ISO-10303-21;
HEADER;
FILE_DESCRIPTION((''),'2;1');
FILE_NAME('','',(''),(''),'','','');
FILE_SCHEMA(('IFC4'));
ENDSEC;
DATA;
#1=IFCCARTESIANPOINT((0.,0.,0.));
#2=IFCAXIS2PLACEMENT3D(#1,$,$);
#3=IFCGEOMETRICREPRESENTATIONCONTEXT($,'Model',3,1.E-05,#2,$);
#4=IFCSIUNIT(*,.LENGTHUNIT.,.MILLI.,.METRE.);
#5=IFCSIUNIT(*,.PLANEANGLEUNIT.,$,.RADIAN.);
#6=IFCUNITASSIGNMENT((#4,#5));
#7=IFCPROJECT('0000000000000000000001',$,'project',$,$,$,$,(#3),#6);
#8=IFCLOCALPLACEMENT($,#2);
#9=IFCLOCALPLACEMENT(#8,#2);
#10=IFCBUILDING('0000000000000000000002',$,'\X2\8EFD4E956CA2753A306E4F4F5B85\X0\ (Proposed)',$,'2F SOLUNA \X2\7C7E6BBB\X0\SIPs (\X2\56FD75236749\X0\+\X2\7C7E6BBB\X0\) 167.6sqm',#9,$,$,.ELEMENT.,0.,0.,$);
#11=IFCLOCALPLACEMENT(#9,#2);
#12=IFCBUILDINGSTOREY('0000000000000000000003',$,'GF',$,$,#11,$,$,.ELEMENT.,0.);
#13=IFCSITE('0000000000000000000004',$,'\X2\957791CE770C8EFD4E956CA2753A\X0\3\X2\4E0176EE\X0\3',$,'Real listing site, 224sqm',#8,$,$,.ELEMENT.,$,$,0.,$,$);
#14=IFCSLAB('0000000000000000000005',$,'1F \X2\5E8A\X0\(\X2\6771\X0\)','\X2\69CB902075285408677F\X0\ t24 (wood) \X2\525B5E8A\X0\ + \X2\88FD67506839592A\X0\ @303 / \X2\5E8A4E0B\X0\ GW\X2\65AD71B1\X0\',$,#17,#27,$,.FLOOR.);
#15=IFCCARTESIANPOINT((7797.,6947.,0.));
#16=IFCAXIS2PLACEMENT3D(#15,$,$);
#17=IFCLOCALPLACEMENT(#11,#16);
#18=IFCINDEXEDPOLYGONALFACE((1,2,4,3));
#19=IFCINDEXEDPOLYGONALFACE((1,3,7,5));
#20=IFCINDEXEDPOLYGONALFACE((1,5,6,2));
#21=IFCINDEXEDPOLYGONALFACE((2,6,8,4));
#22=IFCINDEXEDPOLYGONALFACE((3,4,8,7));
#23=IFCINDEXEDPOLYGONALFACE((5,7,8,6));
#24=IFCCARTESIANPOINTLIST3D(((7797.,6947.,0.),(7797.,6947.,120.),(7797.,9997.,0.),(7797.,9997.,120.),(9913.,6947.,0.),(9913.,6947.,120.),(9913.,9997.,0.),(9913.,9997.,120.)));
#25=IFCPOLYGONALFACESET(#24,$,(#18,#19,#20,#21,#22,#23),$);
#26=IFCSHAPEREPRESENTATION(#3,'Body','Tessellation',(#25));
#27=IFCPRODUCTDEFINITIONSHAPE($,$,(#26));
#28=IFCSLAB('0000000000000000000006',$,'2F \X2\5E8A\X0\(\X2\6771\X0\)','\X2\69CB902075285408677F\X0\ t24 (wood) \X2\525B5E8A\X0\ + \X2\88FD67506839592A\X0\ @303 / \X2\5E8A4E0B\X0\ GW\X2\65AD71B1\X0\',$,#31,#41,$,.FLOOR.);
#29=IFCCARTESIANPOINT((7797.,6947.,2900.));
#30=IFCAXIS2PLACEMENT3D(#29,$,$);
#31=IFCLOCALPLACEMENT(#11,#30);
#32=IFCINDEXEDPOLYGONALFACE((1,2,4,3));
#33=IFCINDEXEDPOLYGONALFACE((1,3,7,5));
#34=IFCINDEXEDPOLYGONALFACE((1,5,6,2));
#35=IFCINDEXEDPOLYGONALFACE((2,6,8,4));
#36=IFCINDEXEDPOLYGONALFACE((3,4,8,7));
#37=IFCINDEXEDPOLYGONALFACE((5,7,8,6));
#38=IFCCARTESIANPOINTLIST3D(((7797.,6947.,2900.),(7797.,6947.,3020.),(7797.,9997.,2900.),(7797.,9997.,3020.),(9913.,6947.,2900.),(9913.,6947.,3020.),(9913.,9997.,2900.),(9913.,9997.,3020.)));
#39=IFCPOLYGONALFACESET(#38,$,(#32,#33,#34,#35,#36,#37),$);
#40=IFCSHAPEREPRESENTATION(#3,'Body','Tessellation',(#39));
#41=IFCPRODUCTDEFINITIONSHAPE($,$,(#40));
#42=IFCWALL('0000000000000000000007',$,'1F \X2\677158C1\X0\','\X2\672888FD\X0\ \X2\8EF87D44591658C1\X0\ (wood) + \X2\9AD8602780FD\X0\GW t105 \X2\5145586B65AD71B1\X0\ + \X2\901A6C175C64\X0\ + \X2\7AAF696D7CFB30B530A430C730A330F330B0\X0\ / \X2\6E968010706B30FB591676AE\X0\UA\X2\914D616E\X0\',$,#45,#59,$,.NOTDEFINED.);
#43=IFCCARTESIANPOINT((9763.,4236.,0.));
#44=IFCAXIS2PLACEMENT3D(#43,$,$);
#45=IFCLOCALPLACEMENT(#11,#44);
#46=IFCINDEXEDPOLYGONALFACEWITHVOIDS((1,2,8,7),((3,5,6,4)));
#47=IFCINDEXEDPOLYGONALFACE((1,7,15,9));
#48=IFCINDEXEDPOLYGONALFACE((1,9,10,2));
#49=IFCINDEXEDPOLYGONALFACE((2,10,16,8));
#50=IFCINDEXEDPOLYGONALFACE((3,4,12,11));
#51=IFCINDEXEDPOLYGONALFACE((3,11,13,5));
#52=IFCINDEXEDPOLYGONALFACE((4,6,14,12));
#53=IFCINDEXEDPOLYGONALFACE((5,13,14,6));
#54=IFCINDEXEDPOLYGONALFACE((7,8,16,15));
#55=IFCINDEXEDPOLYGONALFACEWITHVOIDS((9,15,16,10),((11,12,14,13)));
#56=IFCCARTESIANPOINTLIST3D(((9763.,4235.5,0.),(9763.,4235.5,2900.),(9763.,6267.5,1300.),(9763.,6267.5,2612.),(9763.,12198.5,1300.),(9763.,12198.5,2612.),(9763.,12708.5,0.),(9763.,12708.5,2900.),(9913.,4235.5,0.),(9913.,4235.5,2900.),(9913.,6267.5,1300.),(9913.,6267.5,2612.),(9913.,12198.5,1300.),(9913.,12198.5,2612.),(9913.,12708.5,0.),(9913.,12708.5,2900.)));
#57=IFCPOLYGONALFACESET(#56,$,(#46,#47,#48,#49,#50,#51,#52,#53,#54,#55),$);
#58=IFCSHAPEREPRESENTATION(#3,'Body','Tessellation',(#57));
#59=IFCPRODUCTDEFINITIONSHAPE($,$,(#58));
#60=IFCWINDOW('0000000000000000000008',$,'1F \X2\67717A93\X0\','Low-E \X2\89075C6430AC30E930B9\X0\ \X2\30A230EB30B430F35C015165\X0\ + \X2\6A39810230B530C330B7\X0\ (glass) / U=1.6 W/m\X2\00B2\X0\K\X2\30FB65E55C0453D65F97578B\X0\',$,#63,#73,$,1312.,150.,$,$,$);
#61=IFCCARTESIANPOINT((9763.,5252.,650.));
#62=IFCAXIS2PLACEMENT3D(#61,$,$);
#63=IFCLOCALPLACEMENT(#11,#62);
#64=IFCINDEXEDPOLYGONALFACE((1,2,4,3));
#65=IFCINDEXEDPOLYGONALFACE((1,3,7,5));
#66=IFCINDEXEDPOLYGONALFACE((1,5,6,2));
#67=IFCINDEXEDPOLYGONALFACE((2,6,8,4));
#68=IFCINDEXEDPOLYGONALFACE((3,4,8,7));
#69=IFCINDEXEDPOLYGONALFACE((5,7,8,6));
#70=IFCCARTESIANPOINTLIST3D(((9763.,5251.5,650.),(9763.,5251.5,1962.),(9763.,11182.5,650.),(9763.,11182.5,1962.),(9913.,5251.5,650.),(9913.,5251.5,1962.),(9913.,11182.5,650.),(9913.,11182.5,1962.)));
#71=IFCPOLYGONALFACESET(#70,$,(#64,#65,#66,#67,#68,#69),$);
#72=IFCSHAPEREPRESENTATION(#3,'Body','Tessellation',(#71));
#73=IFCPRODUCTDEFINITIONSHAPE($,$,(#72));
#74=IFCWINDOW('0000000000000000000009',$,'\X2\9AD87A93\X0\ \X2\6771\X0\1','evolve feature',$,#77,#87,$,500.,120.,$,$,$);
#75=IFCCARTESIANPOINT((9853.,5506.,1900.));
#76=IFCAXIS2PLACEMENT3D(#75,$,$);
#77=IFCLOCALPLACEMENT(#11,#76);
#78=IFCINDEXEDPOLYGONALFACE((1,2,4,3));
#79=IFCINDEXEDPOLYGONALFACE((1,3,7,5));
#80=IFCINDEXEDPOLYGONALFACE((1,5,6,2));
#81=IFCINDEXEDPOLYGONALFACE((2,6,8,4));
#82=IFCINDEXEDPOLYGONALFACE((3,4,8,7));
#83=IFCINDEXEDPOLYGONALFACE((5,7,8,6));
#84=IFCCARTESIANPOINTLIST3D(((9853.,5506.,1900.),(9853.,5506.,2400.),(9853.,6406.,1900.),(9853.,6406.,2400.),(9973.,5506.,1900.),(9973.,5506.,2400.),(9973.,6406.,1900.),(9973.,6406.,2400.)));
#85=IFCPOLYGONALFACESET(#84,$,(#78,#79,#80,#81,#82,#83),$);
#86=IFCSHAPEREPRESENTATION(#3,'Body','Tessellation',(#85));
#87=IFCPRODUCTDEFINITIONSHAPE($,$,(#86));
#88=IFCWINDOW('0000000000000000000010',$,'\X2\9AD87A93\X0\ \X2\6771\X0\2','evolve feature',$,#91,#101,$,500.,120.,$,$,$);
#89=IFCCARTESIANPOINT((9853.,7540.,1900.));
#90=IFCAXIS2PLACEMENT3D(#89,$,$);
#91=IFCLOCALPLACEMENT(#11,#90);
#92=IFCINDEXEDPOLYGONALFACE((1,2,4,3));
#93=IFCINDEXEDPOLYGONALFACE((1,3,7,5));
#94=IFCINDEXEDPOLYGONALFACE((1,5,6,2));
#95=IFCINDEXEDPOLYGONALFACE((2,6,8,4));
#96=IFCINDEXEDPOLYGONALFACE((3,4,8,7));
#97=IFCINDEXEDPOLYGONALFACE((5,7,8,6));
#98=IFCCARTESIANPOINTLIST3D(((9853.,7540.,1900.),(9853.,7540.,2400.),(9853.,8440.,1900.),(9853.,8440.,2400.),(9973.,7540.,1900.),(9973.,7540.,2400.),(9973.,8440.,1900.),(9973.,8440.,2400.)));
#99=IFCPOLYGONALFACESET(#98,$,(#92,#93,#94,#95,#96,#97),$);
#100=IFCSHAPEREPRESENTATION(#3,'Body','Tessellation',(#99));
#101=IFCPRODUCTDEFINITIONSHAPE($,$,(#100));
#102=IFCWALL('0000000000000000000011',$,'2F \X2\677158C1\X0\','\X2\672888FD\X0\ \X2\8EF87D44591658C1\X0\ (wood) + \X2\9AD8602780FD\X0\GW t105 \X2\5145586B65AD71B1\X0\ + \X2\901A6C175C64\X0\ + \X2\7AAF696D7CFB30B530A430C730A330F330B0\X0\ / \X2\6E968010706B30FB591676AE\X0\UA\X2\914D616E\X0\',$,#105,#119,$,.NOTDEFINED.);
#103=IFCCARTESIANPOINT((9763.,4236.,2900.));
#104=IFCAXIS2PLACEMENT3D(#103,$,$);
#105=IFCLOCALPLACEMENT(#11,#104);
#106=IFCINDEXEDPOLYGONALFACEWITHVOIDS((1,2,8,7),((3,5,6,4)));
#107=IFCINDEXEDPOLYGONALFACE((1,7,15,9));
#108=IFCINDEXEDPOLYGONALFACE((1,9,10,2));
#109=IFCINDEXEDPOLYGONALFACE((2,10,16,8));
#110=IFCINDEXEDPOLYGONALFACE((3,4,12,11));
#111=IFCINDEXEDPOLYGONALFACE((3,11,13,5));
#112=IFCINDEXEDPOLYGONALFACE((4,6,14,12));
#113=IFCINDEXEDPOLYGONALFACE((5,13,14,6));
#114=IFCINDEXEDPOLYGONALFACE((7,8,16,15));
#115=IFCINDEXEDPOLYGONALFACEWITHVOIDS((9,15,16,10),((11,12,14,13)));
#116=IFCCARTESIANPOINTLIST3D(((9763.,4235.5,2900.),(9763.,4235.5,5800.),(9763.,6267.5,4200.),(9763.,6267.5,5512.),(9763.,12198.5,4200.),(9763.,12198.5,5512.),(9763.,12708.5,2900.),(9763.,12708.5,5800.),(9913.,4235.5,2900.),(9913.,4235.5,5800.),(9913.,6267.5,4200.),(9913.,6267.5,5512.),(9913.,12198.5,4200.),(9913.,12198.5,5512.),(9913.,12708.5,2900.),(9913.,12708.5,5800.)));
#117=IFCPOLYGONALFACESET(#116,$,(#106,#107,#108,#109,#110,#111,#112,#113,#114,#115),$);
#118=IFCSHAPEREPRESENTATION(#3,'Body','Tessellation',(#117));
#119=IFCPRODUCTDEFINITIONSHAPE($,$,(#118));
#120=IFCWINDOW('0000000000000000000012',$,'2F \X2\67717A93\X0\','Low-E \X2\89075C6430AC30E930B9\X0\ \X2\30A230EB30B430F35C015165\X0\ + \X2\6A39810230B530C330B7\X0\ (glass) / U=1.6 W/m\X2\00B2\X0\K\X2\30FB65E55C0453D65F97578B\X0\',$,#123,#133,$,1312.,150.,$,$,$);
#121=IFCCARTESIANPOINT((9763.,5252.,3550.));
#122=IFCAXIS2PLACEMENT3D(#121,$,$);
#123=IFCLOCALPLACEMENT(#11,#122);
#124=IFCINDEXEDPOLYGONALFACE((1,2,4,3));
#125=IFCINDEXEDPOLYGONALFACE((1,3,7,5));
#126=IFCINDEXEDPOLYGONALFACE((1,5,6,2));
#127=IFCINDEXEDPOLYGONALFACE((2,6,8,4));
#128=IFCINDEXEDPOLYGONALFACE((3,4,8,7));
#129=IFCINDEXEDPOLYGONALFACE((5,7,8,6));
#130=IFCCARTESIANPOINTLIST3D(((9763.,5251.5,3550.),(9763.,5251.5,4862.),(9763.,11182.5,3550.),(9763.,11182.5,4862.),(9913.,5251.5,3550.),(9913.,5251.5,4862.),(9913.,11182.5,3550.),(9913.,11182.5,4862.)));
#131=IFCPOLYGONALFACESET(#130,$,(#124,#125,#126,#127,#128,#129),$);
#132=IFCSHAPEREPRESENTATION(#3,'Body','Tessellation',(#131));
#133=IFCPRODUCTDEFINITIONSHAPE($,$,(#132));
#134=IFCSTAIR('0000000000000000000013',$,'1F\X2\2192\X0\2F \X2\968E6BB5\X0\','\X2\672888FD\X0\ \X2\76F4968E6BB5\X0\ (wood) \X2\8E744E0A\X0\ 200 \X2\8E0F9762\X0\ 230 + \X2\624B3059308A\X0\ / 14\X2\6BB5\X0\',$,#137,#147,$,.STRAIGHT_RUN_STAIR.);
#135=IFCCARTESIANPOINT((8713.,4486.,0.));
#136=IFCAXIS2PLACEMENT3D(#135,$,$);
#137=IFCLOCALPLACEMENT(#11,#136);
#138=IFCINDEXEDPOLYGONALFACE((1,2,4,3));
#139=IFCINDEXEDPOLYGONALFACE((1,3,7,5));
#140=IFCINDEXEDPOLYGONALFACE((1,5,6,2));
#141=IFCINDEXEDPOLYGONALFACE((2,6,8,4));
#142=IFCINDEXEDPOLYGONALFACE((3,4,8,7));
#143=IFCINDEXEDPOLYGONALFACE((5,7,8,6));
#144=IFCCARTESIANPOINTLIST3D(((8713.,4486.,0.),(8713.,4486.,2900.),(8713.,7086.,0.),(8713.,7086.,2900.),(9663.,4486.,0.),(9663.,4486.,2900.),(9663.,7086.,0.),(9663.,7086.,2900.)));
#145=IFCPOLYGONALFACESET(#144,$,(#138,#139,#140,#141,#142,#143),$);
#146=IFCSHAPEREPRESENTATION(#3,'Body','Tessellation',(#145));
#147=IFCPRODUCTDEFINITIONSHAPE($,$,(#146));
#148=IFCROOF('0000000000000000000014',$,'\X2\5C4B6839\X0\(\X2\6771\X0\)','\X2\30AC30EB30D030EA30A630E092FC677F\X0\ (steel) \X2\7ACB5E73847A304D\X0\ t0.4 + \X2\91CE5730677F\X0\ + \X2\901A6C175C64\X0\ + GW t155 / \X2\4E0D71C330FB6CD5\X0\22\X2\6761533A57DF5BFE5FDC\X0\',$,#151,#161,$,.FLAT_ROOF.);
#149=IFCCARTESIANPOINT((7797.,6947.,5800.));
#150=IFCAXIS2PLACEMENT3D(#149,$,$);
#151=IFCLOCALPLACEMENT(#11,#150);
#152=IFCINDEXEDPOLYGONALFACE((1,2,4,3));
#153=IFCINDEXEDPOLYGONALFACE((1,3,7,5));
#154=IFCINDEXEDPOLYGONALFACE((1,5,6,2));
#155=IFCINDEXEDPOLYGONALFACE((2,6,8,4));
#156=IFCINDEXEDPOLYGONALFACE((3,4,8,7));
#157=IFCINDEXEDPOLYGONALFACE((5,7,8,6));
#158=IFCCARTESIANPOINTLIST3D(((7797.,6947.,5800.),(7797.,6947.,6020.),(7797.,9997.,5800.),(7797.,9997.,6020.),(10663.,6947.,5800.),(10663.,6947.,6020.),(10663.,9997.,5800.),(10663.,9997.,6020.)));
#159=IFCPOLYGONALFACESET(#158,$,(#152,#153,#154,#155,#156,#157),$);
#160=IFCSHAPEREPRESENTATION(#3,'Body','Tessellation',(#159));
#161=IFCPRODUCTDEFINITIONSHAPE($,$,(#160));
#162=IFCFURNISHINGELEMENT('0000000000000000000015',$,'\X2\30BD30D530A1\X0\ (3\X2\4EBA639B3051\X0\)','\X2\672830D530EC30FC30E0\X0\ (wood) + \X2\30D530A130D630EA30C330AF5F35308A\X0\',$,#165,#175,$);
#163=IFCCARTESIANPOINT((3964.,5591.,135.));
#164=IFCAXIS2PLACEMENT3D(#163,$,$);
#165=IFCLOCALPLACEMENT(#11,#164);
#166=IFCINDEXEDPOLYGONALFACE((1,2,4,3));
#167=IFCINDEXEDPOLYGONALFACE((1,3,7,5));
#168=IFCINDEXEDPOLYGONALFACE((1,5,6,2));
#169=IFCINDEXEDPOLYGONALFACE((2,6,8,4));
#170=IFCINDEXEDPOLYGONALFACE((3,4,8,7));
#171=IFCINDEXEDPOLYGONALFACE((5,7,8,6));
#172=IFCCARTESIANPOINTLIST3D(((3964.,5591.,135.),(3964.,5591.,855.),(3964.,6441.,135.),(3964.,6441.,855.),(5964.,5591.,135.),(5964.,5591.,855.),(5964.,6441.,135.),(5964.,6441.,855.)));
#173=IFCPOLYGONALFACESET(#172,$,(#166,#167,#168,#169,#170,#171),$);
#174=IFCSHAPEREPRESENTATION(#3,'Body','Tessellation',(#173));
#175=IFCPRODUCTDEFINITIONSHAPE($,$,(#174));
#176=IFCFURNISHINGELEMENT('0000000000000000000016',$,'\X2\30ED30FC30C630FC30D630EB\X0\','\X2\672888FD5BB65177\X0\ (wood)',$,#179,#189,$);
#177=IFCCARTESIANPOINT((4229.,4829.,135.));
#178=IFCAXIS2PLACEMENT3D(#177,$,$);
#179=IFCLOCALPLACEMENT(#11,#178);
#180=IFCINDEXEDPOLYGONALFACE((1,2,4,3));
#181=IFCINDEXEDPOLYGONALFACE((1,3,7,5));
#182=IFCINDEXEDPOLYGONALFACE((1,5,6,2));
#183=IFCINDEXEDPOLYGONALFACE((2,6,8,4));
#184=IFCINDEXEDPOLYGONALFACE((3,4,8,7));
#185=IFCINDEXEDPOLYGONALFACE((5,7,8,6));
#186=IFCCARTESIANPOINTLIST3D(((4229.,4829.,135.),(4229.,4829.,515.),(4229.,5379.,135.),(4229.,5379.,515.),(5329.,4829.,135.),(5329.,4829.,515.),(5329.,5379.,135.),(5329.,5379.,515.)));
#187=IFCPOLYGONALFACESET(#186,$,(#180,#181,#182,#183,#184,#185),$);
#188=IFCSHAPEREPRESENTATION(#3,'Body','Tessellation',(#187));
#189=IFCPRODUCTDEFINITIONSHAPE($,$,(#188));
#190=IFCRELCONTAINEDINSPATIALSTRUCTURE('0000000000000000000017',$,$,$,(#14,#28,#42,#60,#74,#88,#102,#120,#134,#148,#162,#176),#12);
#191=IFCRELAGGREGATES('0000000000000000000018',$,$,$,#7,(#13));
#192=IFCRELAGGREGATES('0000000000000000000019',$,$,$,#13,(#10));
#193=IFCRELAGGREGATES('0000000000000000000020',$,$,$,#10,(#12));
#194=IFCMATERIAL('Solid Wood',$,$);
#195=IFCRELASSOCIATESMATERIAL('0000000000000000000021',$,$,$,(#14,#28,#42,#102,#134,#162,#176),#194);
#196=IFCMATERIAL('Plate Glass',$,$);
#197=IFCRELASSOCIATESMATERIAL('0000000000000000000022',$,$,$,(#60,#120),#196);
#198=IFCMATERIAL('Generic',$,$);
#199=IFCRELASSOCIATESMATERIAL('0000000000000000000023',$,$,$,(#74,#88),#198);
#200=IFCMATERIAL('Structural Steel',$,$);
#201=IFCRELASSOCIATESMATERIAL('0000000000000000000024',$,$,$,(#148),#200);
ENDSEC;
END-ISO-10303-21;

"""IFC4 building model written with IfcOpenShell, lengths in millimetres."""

from ifc_helpers import new_model, si_unit, frame, frame_2d, origin, place, context, project, spatial, rectangle, extrude, material, element, fill, save


model = new_model("IFC4")

# Units and contexts
model_context = context("Model", 3, precision=1e-05, world=origin())
ifc_project = project(units=[si_unit("LENGTHUNIT", "METRE", prefix="MILLI"), si_unit("PLANEANGLEUNIT", "RADIAN")], contexts=[model_context])

# Site, building, storey
site_placement = place(None, origin())
site = spatial("IfcSite", under=ifc_project, at=site_placement, Name="長野県軽井沢町3丁目3", ObjectType="Real listing site, 224sqm", CompositionType="ELEMENT", RefElevation=0.0)
building_placement = place(site_placement, origin())
building = spatial("IfcBuilding", under=site, at=building_placement, Name="軽井沢町の住宅 (Proposed)", ObjectType="2F SOLUNA 籾殻SIPs (国産杉+籾殻) 167.6sqm", CompositionType="ELEMENT", ElevationOfRefHeight=0.0, ElevationOfTerrain=0.0)
storey_placement = place(building_placement, origin())
storey = spatial("IfcBuildingStorey", under=building, at=storey_placement, Name="GF", CompositionType="ELEMENT", Elevation=0.0)

# Slabs
ifc_material_1 = material(Name="Solid Wood")
slab_1_placement = place(storey_placement, frame((7797.0, 6947.0, 0.0)))
element("IfcSlab", 1, at=slab_1_placement, inside=storey, material=ifc_material_1, Name="1F 床(東)", Description="構造用合板 t24 (wood) 剛床 + 製材根太 @303 / 床下 GW断熱", PredefinedType="FLOOR", context=model_context, shape_type="SweptSolid", body=[
    extrude(rectangle(XDim=2116.0, YDim=3050.0, at=frame_2d((1058.0, 1525.0))), frame((7797.0, 6947.0, 0.0)), (0.0, 0.0, 1.0), 120.0),
])
slab_2_placement = place(storey_placement, frame((7797.0, 6947.0, 2900.0)))
element("IfcSlab", 2, at=slab_2_placement, inside=storey, material=ifc_material_1, Name="2F 床(東)", Description="構造用合板 t24 (wood) 剛床 + 製材根太 @303 / 床下 GW断熱", PredefinedType="FLOOR", context=model_context, shape_type="SweptSolid", body=[
    extrude(rectangle(XDim=2116.0, YDim=3050.0, at=frame_2d((1058.0, 1525.0))), frame((7797.0, 6947.0, 2900.0)), (0.0, 0.0, 1.0), 120.0),
])

# Wall, openings, windows
wall_1_placement = place(storey_placement, frame((9763.0, 4236.0, 0.0)))
wall_1 = element("IfcWall", 3, at=wall_1_placement, inside=storey, material=ifc_material_1, Name="1F 東壁", Description="木製 軸組外壁 (wood) + 高性能GW t105 充填断熱 + 通気層 + 窯業系サイディング / 準耐火・外皮UA配慮", PredefinedType="NOTDEFINED", context=model_context, shape_type="SweptSolid", body=[
    extrude(rectangle(XDim=150.0, YDim=8473.0, at=frame_2d((75.0, 4236.0))), frame((9763.0, 4236.0, 0.0)), (0.0, 0.0, 1.0), 2900.0),
])
opening_1_placement = place(storey_placement, frame((9763.0, 5252.0, 650.0)))
opening_1 = element("IfcOpeningElement", 4, at=opening_1_placement, cuts=wall_1, PredefinedType="NOTDEFINED", context=model_context, shape_type="SweptSolid", body=[
    extrude(rectangle(XDim=150.0, YDim=5931.0, at=frame_2d((75.0, 2965.0))), frame((9763.0, 5252.0, 650.0)), (0.0, 0.0, 1.0), 1312.0),
])
opening_2_placement = place(storey_placement, frame((9853.0, 5506.0, 1900.0)))
opening_2 = element("IfcOpeningElement", 5, at=opening_2_placement, cuts=wall_1, PredefinedType="NOTDEFINED", context=model_context, shape_type="SweptSolid", body=[
    extrude(rectangle(XDim=120.0, YDim=900.0, at=frame_2d((60.0, 450.0))), frame((9853.0, 5506.0, 1900.0)), (0.0, 0.0, 1.0), 500.0),
])
opening_3_placement = place(storey_placement, frame((9853.0, 7540.0, 1900.0)))
opening_3 = element("IfcOpeningElement", 6, at=opening_3_placement, cuts=wall_1, PredefinedType="NOTDEFINED", context=model_context, shape_type="SweptSolid", body=[
    extrude(rectangle(XDim=120.0, YDim=900.0, at=frame_2d((60.0, 450.0))), frame((9853.0, 7540.0, 1900.0)), (0.0, 0.0, 1.0), 500.0),
])
ifc_material_2 = material(Name="Plate Glass")
window_1_placement = place(storey_placement, frame((9763.0, 5252.0, 650.0)))
window_1 = element("IfcWindow", 7, at=window_1_placement, inside=storey, material=ifc_material_2, Name="1F 東窓", Description="Low-E 複層ガラス アルゴン封入 + 樹脂サッシ (glass) / U=1.6 W/m²K・日射取得型", OverallHeight=1312.0, OverallWidth=150.0, context=model_context, shape_type="SweptSolid", body=[
    extrude(rectangle(XDim=150.0, YDim=5931.0, at=frame_2d((75.0, 2965.0))), frame((9763.0, 5252.0, 650.0)), (0.0, 0.0, 1.0), 1312.0),
])
fill(opening_1, window_1)
ifc_material_3 = material(Name="Generic")
window_2_placement = place(storey_placement, frame((9853.0, 5506.0, 1900.0)))
window_2 = element("IfcWindow", 8, at=window_2_placement, inside=storey, material=ifc_material_3, Name="高窓 東1", Description="evolve feature", OverallHeight=500.0, OverallWidth=120.0, context=model_context, shape_type="SweptSolid", body=[
    extrude(rectangle(XDim=120.0, YDim=900.0, at=frame_2d((60.0, 450.0))), frame((9853.0, 5506.0, 1900.0)), (0.0, 0.0, 1.0), 500.0),
])
fill(opening_2, window_2)
window_3_placement = place(storey_placement, frame((9853.0, 7540.0, 1900.0)))
window_3 = element("IfcWindow", 9, at=window_3_placement, inside=storey, material=ifc_material_3, Name="高窓 東2", Description="evolve feature", OverallHeight=500.0, OverallWidth=120.0, context=model_context, shape_type="SweptSolid", body=[
    extrude(rectangle(XDim=120.0, YDim=900.0, at=frame_2d((60.0, 450.0))), frame((9853.0, 7540.0, 1900.0)), (0.0, 0.0, 1.0), 500.0),
])
fill(opening_3, window_3)

# Wall, opening, window
wall_2_placement = place(storey_placement, frame((9763.0, 4236.0, 2900.0)))
wall_2 = element("IfcWall", 10, at=wall_2_placement, inside=storey, material=ifc_material_1, Name="2F 東壁", Description="木製 軸組外壁 (wood) + 高性能GW t105 充填断熱 + 通気層 + 窯業系サイディング / 準耐火・外皮UA配慮", PredefinedType="NOTDEFINED", context=model_context, shape_type="SweptSolid", body=[
    extrude(rectangle(XDim=150.0, YDim=8473.0, at=frame_2d((75.0, 4236.0))), frame((9763.0, 4236.0, 2900.0)), (0.0, 0.0, 1.0), 2900.0),
])
opening_4_placement = place(storey_placement, frame((9763.0, 5252.0, 3550.0)))
opening_4 = element("IfcOpeningElement", 11, at=opening_4_placement, cuts=wall_2, PredefinedType="NOTDEFINED", context=model_context, shape_type="SweptSolid", body=[
    extrude(rectangle(XDim=150.0, YDim=5931.0, at=frame_2d((75.0, 2965.0))), frame((9763.0, 5252.0, 3550.0)), (0.0, 0.0, 1.0), 1312.0),
])
window_4_placement = place(storey_placement, frame((9763.0, 5252.0, 3550.0)))
window_4 = element("IfcWindow", 12, at=window_4_placement, inside=storey, material=ifc_material_2, Name="2F 東窓", Description="Low-E 複層ガラス アルゴン封入 + 樹脂サッシ (glass) / U=1.6 W/m²K・日射取得型", OverallHeight=1312.0, OverallWidth=150.0, context=model_context, shape_type="SweptSolid", body=[
    extrude(rectangle(XDim=150.0, YDim=5931.0, at=frame_2d((75.0, 2965.0))), frame((9763.0, 5252.0, 3550.0)), (0.0, 0.0, 1.0), 1312.0),
])
fill(opening_4, window_4)

# Stair
stair_placement = place(storey_placement, frame((8713.0, 4486.0, 0.0)))
element("IfcStair", 13, at=stair_placement, inside=storey, material=ifc_material_1, Name="1F→2F 階段", Description="木製 直階段 (wood) 蹴上 200 踏面 230 + 手すり / 14段", PredefinedType="STRAIGHT_RUN_STAIR", context=model_context, shape_type="SweptSolid", body=[
    extrude(rectangle(XDim=950.0, YDim=2600.0, at=frame_2d((475.0, 1300.0))), frame((8713.0, 4486.0, 0.0)), (0.0, 0.0, 1.0), 2900.0),
])

# Roof
ifc_material_4 = material(Name="Structural Steel")
roof_placement = place(storey_placement, frame((7797.0, 6947.0, 5800.0)))
element("IfcRoof", 14, at=roof_placement, inside=storey, material=ifc_material_4, Name="屋根(東)", Description="ガルバリウム鋼板 (steel) 立平葺き t0.4 + 野地板 + 通気層 + GW t155 / 不燃・法22条区域対応", PredefinedType="FLAT_ROOF", context=model_context, shape_type="SweptSolid", body=[
    extrude(rectangle(XDim=2866.0, YDim=3050.0, at=frame_2d((1433.0, 1525.0))), frame((7797.0, 6947.0, 5800.0)), (0.0, 0.0, 1.0), 220.0),
])

# Furnishing elements
furnishing_1_placement = place(storey_placement, frame((3964.0, 5591.0, 135.0)))
element("IfcFurnishingElement", 15, at=furnishing_1_placement, inside=storey, material=ifc_material_1, Name="ソファ (3人掛け)", Description="木フレーム (wood) + ファブリック張り", context=model_context, shape_type="SweptSolid", body=[
    extrude(rectangle(XDim=2000.0, YDim=850.0, at=frame_2d((1000.0, 425.0))), frame((3964.0, 5591.0, 135.0)), (0.0, 0.0, 1.0), 720.0),
])
furnishing_2_placement = place(storey_placement, frame((4229.0, 4829.0, 135.0)))
element("IfcFurnishingElement", 16, at=furnishing_2_placement, inside=storey, material=ifc_material_1, Name="ローテーブル", Description="木製家具 (wood)", context=model_context, shape_type="SweptSolid", body=[
    extrude(rectangle(XDim=1100.0, YDim=550.0, at=frame_2d((550.0, 275.0))), frame((4229.0, 4829.0, 135.0)), (0.0, 0.0, 1.0), 380.0),
])

save(model, "model.ifc")
